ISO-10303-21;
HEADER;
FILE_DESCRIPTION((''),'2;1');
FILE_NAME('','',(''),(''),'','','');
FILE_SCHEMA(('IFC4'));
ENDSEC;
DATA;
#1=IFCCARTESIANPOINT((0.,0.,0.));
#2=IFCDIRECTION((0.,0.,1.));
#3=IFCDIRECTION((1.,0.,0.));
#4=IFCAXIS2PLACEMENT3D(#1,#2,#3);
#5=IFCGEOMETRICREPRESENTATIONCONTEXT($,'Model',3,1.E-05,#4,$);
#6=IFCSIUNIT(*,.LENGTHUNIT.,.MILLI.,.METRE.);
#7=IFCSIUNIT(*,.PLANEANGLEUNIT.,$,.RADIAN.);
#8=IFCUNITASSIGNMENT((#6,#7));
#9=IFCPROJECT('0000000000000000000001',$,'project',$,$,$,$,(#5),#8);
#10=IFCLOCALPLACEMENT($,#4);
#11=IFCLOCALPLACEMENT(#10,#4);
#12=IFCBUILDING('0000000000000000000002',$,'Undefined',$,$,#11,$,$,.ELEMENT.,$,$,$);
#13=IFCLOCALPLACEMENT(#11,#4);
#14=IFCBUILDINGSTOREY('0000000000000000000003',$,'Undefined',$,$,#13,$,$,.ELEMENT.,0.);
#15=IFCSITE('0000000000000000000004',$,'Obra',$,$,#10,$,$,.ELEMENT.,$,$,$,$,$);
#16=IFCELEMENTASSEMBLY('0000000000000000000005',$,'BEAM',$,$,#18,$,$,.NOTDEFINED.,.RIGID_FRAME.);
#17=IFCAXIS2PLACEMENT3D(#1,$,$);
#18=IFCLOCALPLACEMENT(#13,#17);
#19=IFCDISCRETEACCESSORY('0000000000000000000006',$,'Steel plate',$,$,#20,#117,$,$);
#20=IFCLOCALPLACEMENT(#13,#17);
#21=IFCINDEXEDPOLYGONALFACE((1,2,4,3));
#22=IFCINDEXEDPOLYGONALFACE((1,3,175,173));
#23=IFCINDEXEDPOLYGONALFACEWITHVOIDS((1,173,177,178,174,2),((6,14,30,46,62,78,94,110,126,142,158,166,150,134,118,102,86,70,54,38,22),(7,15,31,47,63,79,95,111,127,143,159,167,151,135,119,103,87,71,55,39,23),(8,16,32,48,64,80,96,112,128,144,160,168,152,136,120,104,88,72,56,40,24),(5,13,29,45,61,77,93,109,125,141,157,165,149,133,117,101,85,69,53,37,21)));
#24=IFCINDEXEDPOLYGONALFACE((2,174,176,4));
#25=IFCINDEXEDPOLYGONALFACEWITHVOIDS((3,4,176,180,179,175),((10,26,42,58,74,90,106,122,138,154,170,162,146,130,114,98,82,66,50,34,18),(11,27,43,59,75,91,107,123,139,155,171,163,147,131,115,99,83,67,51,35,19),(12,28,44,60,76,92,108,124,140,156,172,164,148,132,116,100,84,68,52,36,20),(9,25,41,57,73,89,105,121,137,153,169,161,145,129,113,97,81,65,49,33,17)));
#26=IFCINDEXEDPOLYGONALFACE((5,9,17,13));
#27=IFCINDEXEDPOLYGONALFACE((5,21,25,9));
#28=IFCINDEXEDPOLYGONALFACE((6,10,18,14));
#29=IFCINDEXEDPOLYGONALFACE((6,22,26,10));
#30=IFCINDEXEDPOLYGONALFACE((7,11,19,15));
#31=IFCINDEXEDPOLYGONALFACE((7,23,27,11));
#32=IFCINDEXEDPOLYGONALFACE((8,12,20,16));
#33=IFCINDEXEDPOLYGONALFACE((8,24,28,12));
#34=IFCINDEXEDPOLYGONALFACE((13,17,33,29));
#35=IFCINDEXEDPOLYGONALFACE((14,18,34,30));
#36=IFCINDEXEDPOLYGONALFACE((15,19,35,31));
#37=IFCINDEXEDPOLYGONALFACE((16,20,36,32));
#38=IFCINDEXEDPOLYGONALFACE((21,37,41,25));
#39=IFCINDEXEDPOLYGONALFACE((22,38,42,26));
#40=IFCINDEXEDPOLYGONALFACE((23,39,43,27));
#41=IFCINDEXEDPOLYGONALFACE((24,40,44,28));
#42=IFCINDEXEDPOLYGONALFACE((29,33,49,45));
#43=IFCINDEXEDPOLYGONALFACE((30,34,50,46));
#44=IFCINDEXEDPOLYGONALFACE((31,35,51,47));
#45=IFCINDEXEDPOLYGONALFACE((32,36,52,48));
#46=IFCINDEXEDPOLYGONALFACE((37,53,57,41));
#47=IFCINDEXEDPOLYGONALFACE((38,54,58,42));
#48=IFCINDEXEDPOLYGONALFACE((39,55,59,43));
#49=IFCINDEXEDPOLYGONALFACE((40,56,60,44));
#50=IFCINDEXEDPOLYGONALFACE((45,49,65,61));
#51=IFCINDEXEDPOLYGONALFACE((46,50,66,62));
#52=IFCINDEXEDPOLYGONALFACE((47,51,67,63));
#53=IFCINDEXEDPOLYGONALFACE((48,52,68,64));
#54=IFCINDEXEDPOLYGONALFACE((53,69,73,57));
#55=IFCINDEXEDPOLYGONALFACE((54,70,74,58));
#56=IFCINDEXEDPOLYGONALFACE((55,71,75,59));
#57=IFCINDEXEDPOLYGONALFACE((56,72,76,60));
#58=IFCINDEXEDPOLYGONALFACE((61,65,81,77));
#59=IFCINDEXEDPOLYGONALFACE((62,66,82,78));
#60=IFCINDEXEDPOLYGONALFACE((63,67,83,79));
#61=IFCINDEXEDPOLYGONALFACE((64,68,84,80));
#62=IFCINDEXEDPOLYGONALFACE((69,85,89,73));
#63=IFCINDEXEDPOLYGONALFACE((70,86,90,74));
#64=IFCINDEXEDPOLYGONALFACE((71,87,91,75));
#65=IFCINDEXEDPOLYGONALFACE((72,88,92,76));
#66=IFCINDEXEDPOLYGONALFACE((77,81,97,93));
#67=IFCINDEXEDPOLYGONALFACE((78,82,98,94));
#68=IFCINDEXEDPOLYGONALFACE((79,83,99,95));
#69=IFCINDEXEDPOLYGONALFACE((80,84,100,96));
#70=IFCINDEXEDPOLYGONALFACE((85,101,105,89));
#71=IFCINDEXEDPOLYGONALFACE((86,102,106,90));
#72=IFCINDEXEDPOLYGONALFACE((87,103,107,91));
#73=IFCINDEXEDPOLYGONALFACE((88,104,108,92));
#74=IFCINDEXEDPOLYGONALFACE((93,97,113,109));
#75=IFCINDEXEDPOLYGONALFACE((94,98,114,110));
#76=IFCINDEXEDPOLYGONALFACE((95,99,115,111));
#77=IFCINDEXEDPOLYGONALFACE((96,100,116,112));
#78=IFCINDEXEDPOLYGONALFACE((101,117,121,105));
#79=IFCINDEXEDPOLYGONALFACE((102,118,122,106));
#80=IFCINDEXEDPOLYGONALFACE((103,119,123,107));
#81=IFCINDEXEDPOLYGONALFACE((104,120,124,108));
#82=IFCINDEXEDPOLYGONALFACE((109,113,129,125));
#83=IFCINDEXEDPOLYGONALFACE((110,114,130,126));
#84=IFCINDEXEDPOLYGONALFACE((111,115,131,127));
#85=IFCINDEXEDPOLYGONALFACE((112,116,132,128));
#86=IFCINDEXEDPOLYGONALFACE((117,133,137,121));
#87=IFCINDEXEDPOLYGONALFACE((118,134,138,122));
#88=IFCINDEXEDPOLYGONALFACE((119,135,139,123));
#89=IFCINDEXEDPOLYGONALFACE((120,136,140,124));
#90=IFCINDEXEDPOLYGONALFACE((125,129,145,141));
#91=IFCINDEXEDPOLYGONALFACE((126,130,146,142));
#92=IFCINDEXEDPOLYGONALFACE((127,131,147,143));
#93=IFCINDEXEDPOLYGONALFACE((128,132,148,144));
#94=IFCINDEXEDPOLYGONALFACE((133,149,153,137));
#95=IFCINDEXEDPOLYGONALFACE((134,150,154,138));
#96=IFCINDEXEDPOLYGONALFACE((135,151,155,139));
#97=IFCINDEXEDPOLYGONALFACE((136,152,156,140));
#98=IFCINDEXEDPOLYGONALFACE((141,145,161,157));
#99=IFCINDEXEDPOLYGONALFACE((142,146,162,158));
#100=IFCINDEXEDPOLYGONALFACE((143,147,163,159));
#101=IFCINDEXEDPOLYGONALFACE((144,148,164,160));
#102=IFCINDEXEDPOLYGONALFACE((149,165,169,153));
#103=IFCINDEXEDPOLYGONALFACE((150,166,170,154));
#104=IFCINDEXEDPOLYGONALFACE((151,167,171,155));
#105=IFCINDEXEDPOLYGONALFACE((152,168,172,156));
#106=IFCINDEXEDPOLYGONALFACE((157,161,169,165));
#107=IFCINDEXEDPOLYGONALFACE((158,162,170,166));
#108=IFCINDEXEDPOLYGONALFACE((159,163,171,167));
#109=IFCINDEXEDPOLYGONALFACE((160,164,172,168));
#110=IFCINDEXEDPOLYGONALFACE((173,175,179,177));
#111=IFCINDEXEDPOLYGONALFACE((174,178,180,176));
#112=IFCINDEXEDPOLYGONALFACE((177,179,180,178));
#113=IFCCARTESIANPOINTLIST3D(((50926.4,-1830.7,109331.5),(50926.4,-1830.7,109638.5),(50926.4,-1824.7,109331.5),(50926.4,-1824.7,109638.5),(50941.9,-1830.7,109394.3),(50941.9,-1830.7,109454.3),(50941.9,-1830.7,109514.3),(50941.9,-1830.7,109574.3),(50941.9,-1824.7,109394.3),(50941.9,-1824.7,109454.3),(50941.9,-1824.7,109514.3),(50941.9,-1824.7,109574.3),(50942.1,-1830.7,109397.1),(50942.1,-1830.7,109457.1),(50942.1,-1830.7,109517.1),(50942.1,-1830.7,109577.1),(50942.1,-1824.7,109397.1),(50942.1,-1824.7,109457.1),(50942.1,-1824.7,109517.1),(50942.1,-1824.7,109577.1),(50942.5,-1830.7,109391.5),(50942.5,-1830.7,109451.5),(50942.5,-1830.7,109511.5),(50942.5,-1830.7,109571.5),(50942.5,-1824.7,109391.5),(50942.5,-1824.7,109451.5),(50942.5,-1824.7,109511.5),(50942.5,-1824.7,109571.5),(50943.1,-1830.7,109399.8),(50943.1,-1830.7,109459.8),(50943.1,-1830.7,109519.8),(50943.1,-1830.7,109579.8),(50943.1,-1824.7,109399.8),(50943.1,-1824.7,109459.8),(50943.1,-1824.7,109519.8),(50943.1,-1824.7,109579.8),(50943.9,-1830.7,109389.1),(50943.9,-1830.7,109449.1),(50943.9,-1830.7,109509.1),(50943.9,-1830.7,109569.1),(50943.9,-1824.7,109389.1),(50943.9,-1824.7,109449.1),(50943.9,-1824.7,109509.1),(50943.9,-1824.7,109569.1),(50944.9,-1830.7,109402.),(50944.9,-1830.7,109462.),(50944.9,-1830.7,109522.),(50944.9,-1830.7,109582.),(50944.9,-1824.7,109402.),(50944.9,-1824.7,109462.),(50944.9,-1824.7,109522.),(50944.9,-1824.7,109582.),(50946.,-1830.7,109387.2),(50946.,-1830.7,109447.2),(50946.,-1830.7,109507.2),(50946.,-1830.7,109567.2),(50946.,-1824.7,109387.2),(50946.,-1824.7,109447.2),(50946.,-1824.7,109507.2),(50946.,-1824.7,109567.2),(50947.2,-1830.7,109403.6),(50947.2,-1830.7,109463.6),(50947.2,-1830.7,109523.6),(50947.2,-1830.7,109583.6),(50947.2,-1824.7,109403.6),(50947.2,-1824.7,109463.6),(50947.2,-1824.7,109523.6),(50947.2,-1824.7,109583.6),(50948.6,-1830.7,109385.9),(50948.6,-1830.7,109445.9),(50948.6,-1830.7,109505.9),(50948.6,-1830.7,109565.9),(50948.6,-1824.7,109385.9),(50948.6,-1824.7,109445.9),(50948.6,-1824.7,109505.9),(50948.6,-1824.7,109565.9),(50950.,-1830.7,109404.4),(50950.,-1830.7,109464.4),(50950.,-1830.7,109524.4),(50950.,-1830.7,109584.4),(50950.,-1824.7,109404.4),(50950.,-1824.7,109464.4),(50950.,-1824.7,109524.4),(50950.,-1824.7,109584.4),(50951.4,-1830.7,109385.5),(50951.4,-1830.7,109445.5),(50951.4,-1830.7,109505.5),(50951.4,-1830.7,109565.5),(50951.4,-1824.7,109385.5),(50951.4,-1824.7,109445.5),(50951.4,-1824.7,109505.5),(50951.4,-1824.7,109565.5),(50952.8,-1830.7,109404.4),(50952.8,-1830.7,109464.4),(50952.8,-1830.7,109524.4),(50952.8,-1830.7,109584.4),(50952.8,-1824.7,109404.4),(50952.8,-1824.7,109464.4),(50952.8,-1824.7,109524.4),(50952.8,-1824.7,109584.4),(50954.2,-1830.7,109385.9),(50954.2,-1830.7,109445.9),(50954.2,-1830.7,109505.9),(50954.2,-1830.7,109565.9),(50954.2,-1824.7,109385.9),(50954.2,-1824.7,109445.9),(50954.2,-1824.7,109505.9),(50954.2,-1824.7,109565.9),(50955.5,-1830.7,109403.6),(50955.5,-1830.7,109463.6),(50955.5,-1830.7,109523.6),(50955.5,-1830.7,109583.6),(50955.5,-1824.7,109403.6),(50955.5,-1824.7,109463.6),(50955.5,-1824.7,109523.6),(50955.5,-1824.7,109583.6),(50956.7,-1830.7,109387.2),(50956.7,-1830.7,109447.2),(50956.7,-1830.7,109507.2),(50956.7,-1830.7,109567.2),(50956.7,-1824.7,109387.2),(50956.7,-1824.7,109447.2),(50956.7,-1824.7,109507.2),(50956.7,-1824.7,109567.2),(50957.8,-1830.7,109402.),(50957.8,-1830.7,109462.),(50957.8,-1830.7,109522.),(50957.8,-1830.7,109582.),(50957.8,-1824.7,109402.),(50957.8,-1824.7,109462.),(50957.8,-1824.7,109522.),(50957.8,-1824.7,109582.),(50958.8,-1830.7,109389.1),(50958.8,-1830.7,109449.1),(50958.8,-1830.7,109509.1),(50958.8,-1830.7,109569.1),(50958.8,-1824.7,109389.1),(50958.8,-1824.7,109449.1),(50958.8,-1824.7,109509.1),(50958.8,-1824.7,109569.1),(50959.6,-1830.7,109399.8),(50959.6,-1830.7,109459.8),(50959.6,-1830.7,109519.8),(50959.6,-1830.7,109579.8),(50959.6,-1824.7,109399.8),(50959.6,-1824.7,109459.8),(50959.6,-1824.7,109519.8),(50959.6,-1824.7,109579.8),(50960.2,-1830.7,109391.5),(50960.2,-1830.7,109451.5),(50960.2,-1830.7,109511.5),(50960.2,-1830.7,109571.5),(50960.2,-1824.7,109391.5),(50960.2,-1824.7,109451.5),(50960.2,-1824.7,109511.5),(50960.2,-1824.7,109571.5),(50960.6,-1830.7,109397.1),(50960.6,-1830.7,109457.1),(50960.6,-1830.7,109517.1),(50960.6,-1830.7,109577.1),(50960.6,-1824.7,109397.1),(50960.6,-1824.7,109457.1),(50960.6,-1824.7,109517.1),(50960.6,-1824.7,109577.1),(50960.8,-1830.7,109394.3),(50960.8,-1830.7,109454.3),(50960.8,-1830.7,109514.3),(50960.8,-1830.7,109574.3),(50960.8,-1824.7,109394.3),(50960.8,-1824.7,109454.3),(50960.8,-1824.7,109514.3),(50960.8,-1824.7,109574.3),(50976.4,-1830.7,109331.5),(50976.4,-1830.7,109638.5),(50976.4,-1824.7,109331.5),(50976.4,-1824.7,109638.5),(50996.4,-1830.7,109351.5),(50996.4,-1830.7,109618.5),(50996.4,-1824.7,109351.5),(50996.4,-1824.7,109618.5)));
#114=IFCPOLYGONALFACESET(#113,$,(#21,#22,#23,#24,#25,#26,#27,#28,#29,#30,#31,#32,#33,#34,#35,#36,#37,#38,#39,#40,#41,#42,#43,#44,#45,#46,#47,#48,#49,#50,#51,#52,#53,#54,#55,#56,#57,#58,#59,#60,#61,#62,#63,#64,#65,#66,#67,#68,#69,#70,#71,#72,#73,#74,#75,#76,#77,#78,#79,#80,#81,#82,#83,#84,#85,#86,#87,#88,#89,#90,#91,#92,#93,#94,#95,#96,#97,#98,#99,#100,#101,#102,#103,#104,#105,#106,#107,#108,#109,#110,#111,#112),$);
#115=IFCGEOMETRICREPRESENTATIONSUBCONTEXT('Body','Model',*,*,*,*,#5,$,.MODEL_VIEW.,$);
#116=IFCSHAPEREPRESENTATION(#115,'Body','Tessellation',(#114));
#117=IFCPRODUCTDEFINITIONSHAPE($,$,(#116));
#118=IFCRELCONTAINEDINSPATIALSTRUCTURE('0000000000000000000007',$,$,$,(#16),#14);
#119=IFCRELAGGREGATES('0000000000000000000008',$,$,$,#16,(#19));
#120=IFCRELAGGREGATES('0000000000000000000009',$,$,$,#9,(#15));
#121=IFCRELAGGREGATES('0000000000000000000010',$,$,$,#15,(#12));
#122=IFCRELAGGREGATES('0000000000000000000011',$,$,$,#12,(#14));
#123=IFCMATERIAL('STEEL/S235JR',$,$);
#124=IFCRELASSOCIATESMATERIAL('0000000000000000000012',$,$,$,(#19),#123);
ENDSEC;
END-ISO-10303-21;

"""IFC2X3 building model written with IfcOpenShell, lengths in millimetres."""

from ifc_helpers import new_model, si_unit, frame, origin_with_axes, origin_2d_with_axis, place, context, subcontext, project, spatial, polyline, circle, outline, extrude, source, transform, mapped, material, element, aggregate, save


model = new_model("IFC2X3")

# Units and contexts
model_context = context("Model", 3, precision=1e-05, world=origin_with_axes())
body_context = subcontext(model_context, "Body", "Model", "MODEL_VIEW")
ifc_project = project(units=[si_unit("LENGTHUNIT", "METRE", prefix="MILLI"), si_unit("PLANEANGLEUNIT", "RADIAN")], contexts=[model_context])

# Site, building, storey
site_placement = place(None, origin_with_axes())
site = spatial("IfcSite", under=ifc_project, at=site_placement, Name="Obra", CompositionType="ELEMENT")
building_placement = place(site_placement, origin_with_axes())
building = spatial("IfcBuilding", under=site, at=building_placement, Name="Undefined", CompositionType="ELEMENT")
storey_placement = place(building_placement, origin_with_axes())
storey = spatial("IfcBuildingStorey", under=building, at=storey_placement, Name="Undefined", CompositionType="ELEMENT", Elevation=0.0)

# Shared definitions
ifc_material = material(Name="STEEL/S235JR")
shared_shape = source(origin_with_axes(), body_context, "Body", "SweptSolid", [
    extrude(circle(Radius=9.5, at=origin_2d_with_axis()), frame((0.0, -9.8, 0.0), z_axis=(0.0, 1.0, 0.0), x_axis=(1.0, 0.0, 0.0)), (0.0, 0.0, 1.0), 6.2),
])

# Element assembly, discrete accessory, opening
assembly_1_placement = place(storey_placement, origin_with_axes())
assembly_1 = element("IfcElementAssembly", 1, at=assembly_1_placement, inside=storey, Name="BEAM", AssemblyPlace="NOTDEFINED", PredefinedType="RIGID_FRAME")
discrete_accessory_1_placement = place(assembly_1_placement, frame((50926.4, -1827.7, 109331.5), z_axis=(0.0, -1.0, 0.0), x_axis=(1.0, 0.0, 0.0)))
discrete_accessory_1 = element("IfcDiscreteAccessory", 2, at=discrete_accessory_1_placement, material=ifc_material, Name="Steel plate", context=body_context, shape_type="SweptSolid", body=[
    extrude(outline(polyline([(0.0, 0.0), (50.0, 0.0), (70.0, 20.0), (70.0, 287.0), (50.0, 307.0), (0.0, 307.0), (0.0, 0.0)])), frame((0.0, 0.0, -3.0), z_axis=(0.0, 0.0, 1.0), x_axis=(1.0, 0.0, 0.0)), (0.0, 0.0, 1.0), 6.0),
])
opening_1_placement = place(assembly_1_placement, frame((50986.4, -1834.4, 109650.0), z_axis=(-1.0, 0.0, 0.0), x_axis=(0.0, 0.0, -1.0)))
element("IfcOpeningElement", 3, at=opening_1_placement, cuts=discrete_accessory_1, ObjectType="Opening", context=body_context, shape_type="MappedRepresentation", body=[
    mapped(shared_shape, transform((75.0, 0.0, 35.0))),
    mapped(shared_shape, transform((135.0, 0.0, 35.0))),
    mapped(shared_shape, transform((195.0, 0.0, 35.0))),
    mapped(shared_shape, transform((255.0, 0.0, 35.0))),
])
aggregate(assembly_1, [discrete_accessory_1])

save(model, "model.ifc")
